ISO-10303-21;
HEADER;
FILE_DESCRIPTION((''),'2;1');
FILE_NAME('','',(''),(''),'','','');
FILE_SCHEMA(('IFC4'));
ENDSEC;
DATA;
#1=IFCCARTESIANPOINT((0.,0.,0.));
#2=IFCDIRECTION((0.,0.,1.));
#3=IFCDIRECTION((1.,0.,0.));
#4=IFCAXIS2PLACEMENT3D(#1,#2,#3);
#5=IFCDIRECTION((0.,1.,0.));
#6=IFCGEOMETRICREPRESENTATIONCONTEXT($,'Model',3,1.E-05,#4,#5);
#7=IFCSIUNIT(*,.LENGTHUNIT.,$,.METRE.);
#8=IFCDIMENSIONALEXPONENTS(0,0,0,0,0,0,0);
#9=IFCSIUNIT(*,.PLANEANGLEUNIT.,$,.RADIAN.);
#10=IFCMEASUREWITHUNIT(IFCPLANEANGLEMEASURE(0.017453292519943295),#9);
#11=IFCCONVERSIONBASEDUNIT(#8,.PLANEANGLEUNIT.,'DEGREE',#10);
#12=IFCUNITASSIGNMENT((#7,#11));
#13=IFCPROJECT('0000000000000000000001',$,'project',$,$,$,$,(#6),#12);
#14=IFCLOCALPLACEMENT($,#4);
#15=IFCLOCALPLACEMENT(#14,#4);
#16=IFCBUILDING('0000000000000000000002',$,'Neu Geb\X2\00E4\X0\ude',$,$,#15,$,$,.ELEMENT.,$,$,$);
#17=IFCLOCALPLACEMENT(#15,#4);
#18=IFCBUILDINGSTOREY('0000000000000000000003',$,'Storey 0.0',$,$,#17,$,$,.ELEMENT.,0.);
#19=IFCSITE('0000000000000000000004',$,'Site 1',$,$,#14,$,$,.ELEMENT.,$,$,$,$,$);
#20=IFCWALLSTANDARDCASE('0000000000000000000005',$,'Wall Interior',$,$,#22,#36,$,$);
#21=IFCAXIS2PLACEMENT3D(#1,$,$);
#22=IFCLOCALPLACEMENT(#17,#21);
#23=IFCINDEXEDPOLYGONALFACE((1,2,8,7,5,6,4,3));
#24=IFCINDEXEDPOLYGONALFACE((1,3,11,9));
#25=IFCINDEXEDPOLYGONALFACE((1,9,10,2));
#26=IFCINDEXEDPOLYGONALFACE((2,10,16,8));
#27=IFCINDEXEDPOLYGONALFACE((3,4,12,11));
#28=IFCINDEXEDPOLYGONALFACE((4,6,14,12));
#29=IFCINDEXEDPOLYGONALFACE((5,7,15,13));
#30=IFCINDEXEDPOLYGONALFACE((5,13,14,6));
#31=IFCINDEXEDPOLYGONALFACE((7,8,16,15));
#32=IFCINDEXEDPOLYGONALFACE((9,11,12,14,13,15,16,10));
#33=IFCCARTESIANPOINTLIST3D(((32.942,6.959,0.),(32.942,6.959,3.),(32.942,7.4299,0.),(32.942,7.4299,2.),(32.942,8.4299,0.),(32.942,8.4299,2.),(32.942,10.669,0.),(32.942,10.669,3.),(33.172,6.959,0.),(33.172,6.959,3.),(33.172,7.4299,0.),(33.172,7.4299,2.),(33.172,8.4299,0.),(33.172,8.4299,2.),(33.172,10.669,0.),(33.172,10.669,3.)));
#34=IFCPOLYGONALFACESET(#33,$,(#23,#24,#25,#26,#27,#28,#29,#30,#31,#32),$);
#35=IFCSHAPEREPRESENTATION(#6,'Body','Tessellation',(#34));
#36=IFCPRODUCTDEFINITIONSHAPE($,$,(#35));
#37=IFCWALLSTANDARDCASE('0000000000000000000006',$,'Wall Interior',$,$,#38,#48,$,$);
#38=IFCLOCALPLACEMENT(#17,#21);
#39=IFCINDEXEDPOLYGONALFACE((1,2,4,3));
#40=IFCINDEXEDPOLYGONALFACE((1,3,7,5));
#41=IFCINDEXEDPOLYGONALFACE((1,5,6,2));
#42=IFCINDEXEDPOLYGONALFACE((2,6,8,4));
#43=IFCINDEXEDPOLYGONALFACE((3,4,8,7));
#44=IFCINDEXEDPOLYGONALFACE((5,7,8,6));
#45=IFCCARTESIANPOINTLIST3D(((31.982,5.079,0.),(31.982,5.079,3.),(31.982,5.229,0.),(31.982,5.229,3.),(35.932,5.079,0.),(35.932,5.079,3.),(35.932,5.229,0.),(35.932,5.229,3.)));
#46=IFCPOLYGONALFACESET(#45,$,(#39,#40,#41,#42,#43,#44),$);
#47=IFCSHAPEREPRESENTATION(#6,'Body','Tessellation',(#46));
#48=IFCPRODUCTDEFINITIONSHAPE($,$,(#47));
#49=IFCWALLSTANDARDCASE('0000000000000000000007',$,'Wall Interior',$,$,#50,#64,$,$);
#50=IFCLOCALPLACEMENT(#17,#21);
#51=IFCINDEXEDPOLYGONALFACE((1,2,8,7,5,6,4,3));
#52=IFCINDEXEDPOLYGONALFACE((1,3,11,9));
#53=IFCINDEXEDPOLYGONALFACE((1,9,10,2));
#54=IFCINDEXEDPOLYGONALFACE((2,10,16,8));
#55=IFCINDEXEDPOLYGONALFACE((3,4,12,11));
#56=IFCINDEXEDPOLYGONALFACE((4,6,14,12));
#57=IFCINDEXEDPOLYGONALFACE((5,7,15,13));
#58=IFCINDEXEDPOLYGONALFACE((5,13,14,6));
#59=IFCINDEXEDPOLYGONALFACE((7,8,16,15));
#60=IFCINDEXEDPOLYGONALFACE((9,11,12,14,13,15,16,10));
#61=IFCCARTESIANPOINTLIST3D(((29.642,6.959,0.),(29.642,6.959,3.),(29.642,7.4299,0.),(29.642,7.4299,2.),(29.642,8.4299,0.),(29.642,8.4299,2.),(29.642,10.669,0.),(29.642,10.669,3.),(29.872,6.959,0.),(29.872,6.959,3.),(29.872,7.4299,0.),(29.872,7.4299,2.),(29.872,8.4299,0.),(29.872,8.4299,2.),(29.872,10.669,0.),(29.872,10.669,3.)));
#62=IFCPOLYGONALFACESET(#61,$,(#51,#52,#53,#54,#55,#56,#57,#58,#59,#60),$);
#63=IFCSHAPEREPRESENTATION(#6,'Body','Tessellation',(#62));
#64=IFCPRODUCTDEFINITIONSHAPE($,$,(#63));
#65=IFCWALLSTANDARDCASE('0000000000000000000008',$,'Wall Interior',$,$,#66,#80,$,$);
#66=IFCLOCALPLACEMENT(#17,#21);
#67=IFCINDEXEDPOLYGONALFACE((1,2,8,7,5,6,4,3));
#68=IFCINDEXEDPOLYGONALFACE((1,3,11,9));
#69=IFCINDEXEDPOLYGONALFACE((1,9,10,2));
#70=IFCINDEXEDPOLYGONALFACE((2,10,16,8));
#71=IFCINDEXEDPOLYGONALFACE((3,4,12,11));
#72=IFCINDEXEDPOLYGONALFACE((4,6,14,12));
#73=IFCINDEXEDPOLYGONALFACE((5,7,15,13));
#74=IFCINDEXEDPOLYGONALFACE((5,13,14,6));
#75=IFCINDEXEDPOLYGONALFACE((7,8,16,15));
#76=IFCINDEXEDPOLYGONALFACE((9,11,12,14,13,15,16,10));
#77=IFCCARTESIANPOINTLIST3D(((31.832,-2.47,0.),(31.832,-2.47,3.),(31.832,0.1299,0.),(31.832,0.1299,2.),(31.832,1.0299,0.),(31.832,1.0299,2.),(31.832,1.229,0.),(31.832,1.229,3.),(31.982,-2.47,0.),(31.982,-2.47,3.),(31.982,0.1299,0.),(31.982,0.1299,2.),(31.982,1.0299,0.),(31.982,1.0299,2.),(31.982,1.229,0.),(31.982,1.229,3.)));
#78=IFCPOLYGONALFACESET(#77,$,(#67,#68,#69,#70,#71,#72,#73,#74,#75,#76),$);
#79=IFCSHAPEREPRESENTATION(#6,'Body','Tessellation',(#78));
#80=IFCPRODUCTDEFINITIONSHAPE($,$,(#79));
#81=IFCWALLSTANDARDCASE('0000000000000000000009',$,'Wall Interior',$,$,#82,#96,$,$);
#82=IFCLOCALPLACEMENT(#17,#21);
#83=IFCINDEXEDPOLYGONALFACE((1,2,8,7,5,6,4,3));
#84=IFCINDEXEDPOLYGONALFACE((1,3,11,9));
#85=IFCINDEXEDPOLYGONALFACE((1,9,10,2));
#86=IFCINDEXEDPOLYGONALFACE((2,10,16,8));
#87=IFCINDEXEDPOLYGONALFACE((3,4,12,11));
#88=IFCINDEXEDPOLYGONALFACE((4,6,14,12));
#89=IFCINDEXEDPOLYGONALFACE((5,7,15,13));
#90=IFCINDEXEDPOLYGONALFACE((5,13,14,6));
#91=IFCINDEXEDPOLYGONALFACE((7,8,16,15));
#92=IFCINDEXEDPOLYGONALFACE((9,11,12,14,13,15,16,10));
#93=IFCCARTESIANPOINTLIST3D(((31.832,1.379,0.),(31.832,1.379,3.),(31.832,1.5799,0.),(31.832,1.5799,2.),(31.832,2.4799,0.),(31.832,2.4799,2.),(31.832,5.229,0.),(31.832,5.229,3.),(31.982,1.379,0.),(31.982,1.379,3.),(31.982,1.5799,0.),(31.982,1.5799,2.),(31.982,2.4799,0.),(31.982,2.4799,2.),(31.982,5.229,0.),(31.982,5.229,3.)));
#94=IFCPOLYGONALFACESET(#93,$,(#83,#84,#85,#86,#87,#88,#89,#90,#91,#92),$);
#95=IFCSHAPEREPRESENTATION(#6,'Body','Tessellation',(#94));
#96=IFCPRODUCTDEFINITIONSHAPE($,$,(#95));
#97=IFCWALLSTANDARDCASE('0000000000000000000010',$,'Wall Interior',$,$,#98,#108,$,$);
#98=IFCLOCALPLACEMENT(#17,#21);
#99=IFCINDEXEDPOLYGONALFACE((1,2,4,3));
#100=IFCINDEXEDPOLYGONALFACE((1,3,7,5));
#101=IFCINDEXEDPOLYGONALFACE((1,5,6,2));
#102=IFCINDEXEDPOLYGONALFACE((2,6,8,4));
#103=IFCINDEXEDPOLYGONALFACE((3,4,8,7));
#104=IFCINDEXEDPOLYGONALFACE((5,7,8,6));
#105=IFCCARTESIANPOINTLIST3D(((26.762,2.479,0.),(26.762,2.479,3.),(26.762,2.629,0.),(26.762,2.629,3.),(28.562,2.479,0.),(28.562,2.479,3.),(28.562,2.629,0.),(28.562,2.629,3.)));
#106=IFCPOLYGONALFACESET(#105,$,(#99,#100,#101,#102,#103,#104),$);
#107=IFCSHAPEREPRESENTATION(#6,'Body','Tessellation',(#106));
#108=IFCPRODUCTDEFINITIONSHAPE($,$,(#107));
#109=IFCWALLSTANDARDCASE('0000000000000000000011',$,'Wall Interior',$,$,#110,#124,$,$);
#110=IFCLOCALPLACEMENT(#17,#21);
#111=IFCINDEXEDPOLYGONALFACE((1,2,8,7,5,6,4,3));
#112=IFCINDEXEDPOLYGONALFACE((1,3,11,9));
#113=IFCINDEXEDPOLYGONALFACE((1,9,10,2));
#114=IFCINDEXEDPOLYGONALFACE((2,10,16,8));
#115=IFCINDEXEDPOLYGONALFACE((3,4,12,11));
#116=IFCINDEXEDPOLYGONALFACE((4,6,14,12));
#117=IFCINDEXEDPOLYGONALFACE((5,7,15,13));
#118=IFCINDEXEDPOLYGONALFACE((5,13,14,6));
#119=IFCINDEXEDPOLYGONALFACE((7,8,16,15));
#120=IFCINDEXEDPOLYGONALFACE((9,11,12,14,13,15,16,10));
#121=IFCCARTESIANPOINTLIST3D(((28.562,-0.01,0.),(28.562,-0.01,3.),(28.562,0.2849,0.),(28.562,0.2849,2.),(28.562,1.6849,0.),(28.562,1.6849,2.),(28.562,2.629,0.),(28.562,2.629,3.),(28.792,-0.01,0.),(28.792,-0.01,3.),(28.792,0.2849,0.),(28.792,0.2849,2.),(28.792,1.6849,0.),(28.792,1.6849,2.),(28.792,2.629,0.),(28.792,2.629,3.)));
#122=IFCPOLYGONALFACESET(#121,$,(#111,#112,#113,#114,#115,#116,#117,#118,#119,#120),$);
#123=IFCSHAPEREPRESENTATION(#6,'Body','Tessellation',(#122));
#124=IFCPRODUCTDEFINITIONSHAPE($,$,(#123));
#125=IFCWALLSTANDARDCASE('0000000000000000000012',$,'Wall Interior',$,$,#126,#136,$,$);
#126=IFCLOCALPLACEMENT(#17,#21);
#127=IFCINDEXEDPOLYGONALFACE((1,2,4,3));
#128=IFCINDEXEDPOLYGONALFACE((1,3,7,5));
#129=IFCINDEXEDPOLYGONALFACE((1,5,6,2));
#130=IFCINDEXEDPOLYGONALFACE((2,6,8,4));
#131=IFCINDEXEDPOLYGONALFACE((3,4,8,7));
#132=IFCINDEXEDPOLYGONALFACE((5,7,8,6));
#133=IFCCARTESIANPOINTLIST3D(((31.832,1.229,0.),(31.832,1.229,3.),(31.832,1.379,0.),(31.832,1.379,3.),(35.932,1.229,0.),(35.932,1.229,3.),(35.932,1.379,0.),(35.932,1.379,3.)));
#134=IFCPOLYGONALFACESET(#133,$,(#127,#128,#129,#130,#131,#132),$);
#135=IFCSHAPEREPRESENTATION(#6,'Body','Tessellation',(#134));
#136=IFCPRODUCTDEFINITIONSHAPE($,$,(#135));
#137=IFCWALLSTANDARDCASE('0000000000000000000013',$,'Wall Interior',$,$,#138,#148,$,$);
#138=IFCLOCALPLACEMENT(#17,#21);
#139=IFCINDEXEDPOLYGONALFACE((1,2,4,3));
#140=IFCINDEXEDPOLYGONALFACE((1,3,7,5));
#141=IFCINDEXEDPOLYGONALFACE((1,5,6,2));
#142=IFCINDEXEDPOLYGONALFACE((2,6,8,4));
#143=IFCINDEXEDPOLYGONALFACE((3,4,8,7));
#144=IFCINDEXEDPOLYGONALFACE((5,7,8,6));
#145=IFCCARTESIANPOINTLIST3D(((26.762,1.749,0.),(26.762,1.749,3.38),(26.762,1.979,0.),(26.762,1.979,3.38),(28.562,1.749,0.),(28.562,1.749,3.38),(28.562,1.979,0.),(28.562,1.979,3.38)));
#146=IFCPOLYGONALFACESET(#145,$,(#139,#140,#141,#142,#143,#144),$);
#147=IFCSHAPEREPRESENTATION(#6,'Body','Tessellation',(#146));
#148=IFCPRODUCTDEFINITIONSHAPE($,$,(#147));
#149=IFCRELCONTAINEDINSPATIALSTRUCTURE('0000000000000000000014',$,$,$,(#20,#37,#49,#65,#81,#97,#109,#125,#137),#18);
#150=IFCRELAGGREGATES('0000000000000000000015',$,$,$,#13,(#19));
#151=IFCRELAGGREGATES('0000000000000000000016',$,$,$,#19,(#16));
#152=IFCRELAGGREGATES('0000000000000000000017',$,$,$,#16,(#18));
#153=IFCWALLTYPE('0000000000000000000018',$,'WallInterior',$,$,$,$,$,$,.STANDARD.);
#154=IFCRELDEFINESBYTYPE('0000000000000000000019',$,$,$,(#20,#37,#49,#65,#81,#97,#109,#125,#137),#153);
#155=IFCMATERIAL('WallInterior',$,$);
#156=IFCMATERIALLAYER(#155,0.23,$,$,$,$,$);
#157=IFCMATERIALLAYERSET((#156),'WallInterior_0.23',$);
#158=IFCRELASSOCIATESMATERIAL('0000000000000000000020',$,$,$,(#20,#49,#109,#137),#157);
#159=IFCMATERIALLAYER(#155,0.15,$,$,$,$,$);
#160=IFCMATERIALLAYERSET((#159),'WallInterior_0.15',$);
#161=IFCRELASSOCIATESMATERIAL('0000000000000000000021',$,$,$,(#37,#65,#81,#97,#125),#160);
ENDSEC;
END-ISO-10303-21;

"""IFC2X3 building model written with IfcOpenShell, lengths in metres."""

from ifc_helpers import new_model, entity, si_unit, converted_unit, direction, frame, origin_with_axes, place, context, project, spatial, polyline, outline, extrude, material, layer, layer_set, layer_usage, type_object, element, save


model = new_model("IFC2X3")

# Units and contexts
model_context = context("Model", 3, precision=1e-05, world=origin_with_axes(), true_north=direction((0.0, 1.0, 0.0)))
ifc_project = project(units=[si_unit("LENGTHUNIT", "METRE"), converted_unit("PLANEANGLEUNIT", "DEGREE", entity("IfcPlaneAngleMeasure", 0.017453292519943295), si_unit("PLANEANGLEUNIT", "RADIAN"), dimensions=[0, 0, 0, 0, 0, 0, 0])], contexts=[model_context])

# Site, building, storey
site_placement = place(None, origin_with_axes())
site = spatial("IfcSite", under=ifc_project, at=site_placement, Name="Site 1", CompositionType="ELEMENT")
building_placement = place(site_placement, origin_with_axes())
building = spatial("IfcBuilding", under=site, at=building_placement, Name="Neu Gebäude", CompositionType="ELEMENT")
storey_placement = place(building_placement, origin_with_axes())
storey = spatial("IfcBuildingStorey", under=building, at=storey_placement, Name="Storey 0.0", CompositionType="ELEMENT", Elevation=0.0)

# Wall, opening
ifc_material_1 = material(Name="WallInterior")
ifc_layer_1 = layer(ifc_material_1, 0.23)
ifc_layer_set_1 = layer_set([ifc_layer_1], Name="WallInterior_0.23")
ifc_layer_usage_1 = layer_usage(ifc_layer_set_1, "AXIS2", "POSITIVE", -0.115)
wall_type_1 = type_object("IfcWallType", Name="WallInterior", PredefinedType="STANDARD")
wall_1_placement = place(storey_placement, frame((33.057, 6.959, 0.0), z_axis=(0.0, 0.0, 1.0), x_axis=(0.0, 1.0, 0.0)))
wall_1 = element("IfcWallStandardCase", 1, at=wall_1_placement, inside=storey, type_object=wall_type_1, material=ifc_layer_usage_1, Name="Wall Interior", context=model_context, shape_type="SweptSolid", body=[
    extrude(outline(polyline([(3.71, -0.115), (3.71, 0.115), (0.0, 0.115), (0.0, -0.115), (3.71, -0.115)])), origin_with_axes(), (0.0, 0.0, 1.0), 3.0),
])
opening_1_placement = place(wall_1_placement, frame((0.9709, 0.0, 0.0), z_axis=(0.0, 0.0, 1.0), x_axis=(1.0, 0.0, 0.0)))
element("IfcOpeningElement", 2, at=opening_1_placement, cuts=wall_1, context=model_context, shape_type="SweptSolid", body=[
    extrude(outline(polyline([(-0.5, 0.252), (0.5, 0.252), (0.5, -0.252), (-0.5, -0.252), (-0.5, 0.252)])), origin_with_axes(), (0.0, 0.0, 1.0), 2.0),
])

# Wall
ifc_layer_2 = layer(ifc_material_1, 0.15)
ifc_layer_set_2 = layer_set([ifc_layer_2], Name="WallInterior_0.15")
ifc_layer_usage_2 = layer_usage(ifc_layer_set_2, "AXIS2", "POSITIVE", -0.075)
wall_2_placement = place(storey_placement, frame((35.932, 5.154, 0.0), z_axis=(0.0, 0.0, 1.0), x_axis=(-1.0, 0.0, 0.0)))
element("IfcWallStandardCase", 3, at=wall_2_placement, inside=storey, type_object=wall_type_1, material=ifc_layer_usage_2, Name="Wall Interior", context=model_context, shape_type="SweptSolid", body=[
    extrude(outline(polyline([(0.0, -0.075), (3.95, -0.075), (3.95, 0.075), (0.0, 0.075), (0.0, -0.075)])), origin_with_axes(), (0.0, 0.0, 1.0), 3.0),
])

# Walls, openings
wall_3_placement = place(storey_placement, frame((29.757, 6.959, 0.0), z_axis=(0.0, 0.0, 1.0), x_axis=(0.0, 1.0, 0.0)))
wall_3 = element("IfcWallStandardCase", 4, at=wall_3_placement, inside=storey, type_object=wall_type_1, material=ifc_layer_usage_1, Name="Wall Interior", context=model_context, shape_type="SweptSolid", body=[
    extrude(outline(polyline([(3.71, -0.115), (3.71, 0.115), (0.0, 0.115), (0.0, -0.115), (3.71, -0.115)])), origin_with_axes(), (0.0, 0.0, 1.0), 3.0),
])
opening_2_placement = place(wall_3_placement, frame((0.9709, 0.0, 0.0), z_axis=(0.0, 0.0, 1.0), x_axis=(1.0, 0.0, 0.0)))
element("IfcOpeningElement", 5, at=opening_2_placement, cuts=wall_3, context=model_context, shape_type="SweptSolid", body=[
    extrude(outline(polyline([(-0.5, 0.252), (0.5, 0.252), (0.5, -0.252), (-0.5, -0.252), (-0.5, 0.252)])), origin_with_axes(), (0.0, 0.0, 1.0), 2.0),
])
wall_4_placement = place(storey_placement, frame((31.907, -2.47, 0.0), z_axis=(0.0, 0.0, 1.0), x_axis=(0.0, 1.0, 0.0)))
wall_4 = element("IfcWallStandardCase", 6, at=wall_4_placement, inside=storey, type_object=wall_type_1, material=ifc_layer_usage_2, Name="Wall Interior", context=model_context, shape_type="SweptSolid", body=[
    extrude(outline(polyline([(3.699, -0.075), (3.699, 0.075), (0.0, 0.075), (0.0, -0.075), (3.699, -0.075)])), origin_with_axes(), (0.0, 0.0, 1.0), 3.0),
])
opening_3_placement = place(wall_4_placement, frame((3.0499, 0.0, 0.0), z_axis=(0.0, 0.0, 1.0), x_axis=(1.0, 0.0, 0.0)))
element("IfcOpeningElement", 7, at=opening_3_placement, cuts=wall_4, context=model_context, shape_type="SweptSolid", body=[
    extrude(outline(polyline([(-0.45, 0.172), (0.45, 0.172), (0.45, -0.172), (-0.45, -0.172), (-0.45, 0.172)])), origin_with_axes(), (0.0, 0.0, 1.0), 2.0),
])
wall_5_placement = place(storey_placement, frame((31.907, 1.379, 0.0), z_axis=(0.0, 0.0, 1.0), x_axis=(0.0, 1.0, 0.0)))
wall_5 = element("IfcWallStandardCase", 8, at=wall_5_placement, inside=storey, type_object=wall_type_1, material=ifc_layer_usage_2, Name="Wall Interior", context=model_context, shape_type="SweptSolid", body=[
    extrude(outline(polyline([(3.85, -0.075), (3.85, 0.075), (0.0, 0.075), (0.0, -0.075), (3.85, -0.075)])), origin_with_axes(), (0.0, 0.0, 1.0), 3.0),
])
opening_4_placement = place(wall_5_placement, frame((0.6509, 0.0, 0.0), z_axis=(0.0, 0.0, 1.0), x_axis=(1.0, 0.0, 0.0)))
element("IfcOpeningElement", 9, at=opening_4_placement, cuts=wall_5, context=model_context, shape_type="SweptSolid", body=[
    extrude(outline(polyline([(-0.45, 0.172), (0.45, 0.172), (0.45, -0.172), (-0.45, -0.172), (-0.45, 0.172)])), origin_with_axes(), (0.0, 0.0, 1.0), 2.0),
])

# Wall
wall_6_placement = place(storey_placement, frame((28.562, 2.554, 0.0), z_axis=(0.0, 0.0, 1.0), x_axis=(-1.0, 0.0, 0.0)))
element("IfcWallStandardCase", 10, at=wall_6_placement, inside=storey, type_object=wall_type_1, material=ifc_layer_usage_2, Name="Wall Interior", context=model_context, shape_type="SweptSolid", body=[
    extrude(outline(polyline([(0.0, -0.075), (1.8, -0.075), (1.8, 0.075), (0.0, 0.075), (0.0, -0.075)])), origin_with_axes(), (0.0, 0.0, 1.0), 3.0),
])

# Wall, opening
wall_7_placement = place(storey_placement, frame((28.677, -0.01, 0.0), z_axis=(0.0, 0.0, 1.0), x_axis=(0.0, 1.0, 0.0)))
wall_7 = element("IfcWallStandardCase", 11, at=wall_7_placement, inside=storey, type_object=wall_type_1, material=ifc_layer_usage_1, Name="Wall Interior", context=model_context, shape_type="SweptSolid", body=[
    extrude(outline(polyline([(2.639, -0.115), (2.639, 0.115), (0.0, 0.115), (0.0, -0.115), (2.639, -0.115)])), origin_with_axes(), (0.0, 0.0, 1.0), 3.0),
])
opening_5_placement = place(wall_7_placement, frame((0.9949, 0.0, 0.0), z_axis=(0.0, 0.0, 1.0), x_axis=(1.0, 0.0, 0.0)))
element("IfcOpeningElement", 12, at=opening_5_placement, cuts=wall_7, context=model_context, shape_type="SweptSolid", body=[
    extrude(outline(polyline([(-0.7, 0.252), (0.7, 0.252), (0.7, -0.252), (-0.7, -0.252), (-0.7, 0.252)])), origin_with_axes(), (0.0, 0.0, 1.0), 2.0),
])

# Walls
wall_8_placement = place(storey_placement, frame((35.932, 1.304, 0.0), z_axis=(0.0, 0.0, 1.0), x_axis=(-1.0, 0.0, 0.0)))
element("IfcWallStandardCase", 13, at=wall_8_placement, inside=storey, type_object=wall_type_1, material=ifc_layer_usage_2, Name="Wall Interior", context=model_context, shape_type="SweptSolid", body=[
    extrude(outline(polyline([(0.0, -0.075), (4.1, -0.075), (4.1, 0.075), (0.0, 0.075), (0.0, -0.075)])), origin_with_axes(), (0.0, 0.0, 1.0), 3.0),
])
wall_9_placement = place(storey_placement, frame((28.562, 1.864, 0.0), z_axis=(0.0, 0.0, 1.0), x_axis=(-1.0, 0.0, 0.0)))
element("IfcWallStandardCase", 14, at=wall_9_placement, inside=storey, type_object=wall_type_1, material=ifc_layer_usage_1, Name="Wall Interior", context=model_context, shape_type="SweptSolid", body=[
    extrude(outline(polyline([(0.0, -0.115), (1.8, -0.115), (1.8, 0.115), (0.0, 0.115), (0.0, -0.115)])), origin_with_axes(), (0.0, 0.0, 1.0), 3.38),
])

save(model, "model.ifc")
